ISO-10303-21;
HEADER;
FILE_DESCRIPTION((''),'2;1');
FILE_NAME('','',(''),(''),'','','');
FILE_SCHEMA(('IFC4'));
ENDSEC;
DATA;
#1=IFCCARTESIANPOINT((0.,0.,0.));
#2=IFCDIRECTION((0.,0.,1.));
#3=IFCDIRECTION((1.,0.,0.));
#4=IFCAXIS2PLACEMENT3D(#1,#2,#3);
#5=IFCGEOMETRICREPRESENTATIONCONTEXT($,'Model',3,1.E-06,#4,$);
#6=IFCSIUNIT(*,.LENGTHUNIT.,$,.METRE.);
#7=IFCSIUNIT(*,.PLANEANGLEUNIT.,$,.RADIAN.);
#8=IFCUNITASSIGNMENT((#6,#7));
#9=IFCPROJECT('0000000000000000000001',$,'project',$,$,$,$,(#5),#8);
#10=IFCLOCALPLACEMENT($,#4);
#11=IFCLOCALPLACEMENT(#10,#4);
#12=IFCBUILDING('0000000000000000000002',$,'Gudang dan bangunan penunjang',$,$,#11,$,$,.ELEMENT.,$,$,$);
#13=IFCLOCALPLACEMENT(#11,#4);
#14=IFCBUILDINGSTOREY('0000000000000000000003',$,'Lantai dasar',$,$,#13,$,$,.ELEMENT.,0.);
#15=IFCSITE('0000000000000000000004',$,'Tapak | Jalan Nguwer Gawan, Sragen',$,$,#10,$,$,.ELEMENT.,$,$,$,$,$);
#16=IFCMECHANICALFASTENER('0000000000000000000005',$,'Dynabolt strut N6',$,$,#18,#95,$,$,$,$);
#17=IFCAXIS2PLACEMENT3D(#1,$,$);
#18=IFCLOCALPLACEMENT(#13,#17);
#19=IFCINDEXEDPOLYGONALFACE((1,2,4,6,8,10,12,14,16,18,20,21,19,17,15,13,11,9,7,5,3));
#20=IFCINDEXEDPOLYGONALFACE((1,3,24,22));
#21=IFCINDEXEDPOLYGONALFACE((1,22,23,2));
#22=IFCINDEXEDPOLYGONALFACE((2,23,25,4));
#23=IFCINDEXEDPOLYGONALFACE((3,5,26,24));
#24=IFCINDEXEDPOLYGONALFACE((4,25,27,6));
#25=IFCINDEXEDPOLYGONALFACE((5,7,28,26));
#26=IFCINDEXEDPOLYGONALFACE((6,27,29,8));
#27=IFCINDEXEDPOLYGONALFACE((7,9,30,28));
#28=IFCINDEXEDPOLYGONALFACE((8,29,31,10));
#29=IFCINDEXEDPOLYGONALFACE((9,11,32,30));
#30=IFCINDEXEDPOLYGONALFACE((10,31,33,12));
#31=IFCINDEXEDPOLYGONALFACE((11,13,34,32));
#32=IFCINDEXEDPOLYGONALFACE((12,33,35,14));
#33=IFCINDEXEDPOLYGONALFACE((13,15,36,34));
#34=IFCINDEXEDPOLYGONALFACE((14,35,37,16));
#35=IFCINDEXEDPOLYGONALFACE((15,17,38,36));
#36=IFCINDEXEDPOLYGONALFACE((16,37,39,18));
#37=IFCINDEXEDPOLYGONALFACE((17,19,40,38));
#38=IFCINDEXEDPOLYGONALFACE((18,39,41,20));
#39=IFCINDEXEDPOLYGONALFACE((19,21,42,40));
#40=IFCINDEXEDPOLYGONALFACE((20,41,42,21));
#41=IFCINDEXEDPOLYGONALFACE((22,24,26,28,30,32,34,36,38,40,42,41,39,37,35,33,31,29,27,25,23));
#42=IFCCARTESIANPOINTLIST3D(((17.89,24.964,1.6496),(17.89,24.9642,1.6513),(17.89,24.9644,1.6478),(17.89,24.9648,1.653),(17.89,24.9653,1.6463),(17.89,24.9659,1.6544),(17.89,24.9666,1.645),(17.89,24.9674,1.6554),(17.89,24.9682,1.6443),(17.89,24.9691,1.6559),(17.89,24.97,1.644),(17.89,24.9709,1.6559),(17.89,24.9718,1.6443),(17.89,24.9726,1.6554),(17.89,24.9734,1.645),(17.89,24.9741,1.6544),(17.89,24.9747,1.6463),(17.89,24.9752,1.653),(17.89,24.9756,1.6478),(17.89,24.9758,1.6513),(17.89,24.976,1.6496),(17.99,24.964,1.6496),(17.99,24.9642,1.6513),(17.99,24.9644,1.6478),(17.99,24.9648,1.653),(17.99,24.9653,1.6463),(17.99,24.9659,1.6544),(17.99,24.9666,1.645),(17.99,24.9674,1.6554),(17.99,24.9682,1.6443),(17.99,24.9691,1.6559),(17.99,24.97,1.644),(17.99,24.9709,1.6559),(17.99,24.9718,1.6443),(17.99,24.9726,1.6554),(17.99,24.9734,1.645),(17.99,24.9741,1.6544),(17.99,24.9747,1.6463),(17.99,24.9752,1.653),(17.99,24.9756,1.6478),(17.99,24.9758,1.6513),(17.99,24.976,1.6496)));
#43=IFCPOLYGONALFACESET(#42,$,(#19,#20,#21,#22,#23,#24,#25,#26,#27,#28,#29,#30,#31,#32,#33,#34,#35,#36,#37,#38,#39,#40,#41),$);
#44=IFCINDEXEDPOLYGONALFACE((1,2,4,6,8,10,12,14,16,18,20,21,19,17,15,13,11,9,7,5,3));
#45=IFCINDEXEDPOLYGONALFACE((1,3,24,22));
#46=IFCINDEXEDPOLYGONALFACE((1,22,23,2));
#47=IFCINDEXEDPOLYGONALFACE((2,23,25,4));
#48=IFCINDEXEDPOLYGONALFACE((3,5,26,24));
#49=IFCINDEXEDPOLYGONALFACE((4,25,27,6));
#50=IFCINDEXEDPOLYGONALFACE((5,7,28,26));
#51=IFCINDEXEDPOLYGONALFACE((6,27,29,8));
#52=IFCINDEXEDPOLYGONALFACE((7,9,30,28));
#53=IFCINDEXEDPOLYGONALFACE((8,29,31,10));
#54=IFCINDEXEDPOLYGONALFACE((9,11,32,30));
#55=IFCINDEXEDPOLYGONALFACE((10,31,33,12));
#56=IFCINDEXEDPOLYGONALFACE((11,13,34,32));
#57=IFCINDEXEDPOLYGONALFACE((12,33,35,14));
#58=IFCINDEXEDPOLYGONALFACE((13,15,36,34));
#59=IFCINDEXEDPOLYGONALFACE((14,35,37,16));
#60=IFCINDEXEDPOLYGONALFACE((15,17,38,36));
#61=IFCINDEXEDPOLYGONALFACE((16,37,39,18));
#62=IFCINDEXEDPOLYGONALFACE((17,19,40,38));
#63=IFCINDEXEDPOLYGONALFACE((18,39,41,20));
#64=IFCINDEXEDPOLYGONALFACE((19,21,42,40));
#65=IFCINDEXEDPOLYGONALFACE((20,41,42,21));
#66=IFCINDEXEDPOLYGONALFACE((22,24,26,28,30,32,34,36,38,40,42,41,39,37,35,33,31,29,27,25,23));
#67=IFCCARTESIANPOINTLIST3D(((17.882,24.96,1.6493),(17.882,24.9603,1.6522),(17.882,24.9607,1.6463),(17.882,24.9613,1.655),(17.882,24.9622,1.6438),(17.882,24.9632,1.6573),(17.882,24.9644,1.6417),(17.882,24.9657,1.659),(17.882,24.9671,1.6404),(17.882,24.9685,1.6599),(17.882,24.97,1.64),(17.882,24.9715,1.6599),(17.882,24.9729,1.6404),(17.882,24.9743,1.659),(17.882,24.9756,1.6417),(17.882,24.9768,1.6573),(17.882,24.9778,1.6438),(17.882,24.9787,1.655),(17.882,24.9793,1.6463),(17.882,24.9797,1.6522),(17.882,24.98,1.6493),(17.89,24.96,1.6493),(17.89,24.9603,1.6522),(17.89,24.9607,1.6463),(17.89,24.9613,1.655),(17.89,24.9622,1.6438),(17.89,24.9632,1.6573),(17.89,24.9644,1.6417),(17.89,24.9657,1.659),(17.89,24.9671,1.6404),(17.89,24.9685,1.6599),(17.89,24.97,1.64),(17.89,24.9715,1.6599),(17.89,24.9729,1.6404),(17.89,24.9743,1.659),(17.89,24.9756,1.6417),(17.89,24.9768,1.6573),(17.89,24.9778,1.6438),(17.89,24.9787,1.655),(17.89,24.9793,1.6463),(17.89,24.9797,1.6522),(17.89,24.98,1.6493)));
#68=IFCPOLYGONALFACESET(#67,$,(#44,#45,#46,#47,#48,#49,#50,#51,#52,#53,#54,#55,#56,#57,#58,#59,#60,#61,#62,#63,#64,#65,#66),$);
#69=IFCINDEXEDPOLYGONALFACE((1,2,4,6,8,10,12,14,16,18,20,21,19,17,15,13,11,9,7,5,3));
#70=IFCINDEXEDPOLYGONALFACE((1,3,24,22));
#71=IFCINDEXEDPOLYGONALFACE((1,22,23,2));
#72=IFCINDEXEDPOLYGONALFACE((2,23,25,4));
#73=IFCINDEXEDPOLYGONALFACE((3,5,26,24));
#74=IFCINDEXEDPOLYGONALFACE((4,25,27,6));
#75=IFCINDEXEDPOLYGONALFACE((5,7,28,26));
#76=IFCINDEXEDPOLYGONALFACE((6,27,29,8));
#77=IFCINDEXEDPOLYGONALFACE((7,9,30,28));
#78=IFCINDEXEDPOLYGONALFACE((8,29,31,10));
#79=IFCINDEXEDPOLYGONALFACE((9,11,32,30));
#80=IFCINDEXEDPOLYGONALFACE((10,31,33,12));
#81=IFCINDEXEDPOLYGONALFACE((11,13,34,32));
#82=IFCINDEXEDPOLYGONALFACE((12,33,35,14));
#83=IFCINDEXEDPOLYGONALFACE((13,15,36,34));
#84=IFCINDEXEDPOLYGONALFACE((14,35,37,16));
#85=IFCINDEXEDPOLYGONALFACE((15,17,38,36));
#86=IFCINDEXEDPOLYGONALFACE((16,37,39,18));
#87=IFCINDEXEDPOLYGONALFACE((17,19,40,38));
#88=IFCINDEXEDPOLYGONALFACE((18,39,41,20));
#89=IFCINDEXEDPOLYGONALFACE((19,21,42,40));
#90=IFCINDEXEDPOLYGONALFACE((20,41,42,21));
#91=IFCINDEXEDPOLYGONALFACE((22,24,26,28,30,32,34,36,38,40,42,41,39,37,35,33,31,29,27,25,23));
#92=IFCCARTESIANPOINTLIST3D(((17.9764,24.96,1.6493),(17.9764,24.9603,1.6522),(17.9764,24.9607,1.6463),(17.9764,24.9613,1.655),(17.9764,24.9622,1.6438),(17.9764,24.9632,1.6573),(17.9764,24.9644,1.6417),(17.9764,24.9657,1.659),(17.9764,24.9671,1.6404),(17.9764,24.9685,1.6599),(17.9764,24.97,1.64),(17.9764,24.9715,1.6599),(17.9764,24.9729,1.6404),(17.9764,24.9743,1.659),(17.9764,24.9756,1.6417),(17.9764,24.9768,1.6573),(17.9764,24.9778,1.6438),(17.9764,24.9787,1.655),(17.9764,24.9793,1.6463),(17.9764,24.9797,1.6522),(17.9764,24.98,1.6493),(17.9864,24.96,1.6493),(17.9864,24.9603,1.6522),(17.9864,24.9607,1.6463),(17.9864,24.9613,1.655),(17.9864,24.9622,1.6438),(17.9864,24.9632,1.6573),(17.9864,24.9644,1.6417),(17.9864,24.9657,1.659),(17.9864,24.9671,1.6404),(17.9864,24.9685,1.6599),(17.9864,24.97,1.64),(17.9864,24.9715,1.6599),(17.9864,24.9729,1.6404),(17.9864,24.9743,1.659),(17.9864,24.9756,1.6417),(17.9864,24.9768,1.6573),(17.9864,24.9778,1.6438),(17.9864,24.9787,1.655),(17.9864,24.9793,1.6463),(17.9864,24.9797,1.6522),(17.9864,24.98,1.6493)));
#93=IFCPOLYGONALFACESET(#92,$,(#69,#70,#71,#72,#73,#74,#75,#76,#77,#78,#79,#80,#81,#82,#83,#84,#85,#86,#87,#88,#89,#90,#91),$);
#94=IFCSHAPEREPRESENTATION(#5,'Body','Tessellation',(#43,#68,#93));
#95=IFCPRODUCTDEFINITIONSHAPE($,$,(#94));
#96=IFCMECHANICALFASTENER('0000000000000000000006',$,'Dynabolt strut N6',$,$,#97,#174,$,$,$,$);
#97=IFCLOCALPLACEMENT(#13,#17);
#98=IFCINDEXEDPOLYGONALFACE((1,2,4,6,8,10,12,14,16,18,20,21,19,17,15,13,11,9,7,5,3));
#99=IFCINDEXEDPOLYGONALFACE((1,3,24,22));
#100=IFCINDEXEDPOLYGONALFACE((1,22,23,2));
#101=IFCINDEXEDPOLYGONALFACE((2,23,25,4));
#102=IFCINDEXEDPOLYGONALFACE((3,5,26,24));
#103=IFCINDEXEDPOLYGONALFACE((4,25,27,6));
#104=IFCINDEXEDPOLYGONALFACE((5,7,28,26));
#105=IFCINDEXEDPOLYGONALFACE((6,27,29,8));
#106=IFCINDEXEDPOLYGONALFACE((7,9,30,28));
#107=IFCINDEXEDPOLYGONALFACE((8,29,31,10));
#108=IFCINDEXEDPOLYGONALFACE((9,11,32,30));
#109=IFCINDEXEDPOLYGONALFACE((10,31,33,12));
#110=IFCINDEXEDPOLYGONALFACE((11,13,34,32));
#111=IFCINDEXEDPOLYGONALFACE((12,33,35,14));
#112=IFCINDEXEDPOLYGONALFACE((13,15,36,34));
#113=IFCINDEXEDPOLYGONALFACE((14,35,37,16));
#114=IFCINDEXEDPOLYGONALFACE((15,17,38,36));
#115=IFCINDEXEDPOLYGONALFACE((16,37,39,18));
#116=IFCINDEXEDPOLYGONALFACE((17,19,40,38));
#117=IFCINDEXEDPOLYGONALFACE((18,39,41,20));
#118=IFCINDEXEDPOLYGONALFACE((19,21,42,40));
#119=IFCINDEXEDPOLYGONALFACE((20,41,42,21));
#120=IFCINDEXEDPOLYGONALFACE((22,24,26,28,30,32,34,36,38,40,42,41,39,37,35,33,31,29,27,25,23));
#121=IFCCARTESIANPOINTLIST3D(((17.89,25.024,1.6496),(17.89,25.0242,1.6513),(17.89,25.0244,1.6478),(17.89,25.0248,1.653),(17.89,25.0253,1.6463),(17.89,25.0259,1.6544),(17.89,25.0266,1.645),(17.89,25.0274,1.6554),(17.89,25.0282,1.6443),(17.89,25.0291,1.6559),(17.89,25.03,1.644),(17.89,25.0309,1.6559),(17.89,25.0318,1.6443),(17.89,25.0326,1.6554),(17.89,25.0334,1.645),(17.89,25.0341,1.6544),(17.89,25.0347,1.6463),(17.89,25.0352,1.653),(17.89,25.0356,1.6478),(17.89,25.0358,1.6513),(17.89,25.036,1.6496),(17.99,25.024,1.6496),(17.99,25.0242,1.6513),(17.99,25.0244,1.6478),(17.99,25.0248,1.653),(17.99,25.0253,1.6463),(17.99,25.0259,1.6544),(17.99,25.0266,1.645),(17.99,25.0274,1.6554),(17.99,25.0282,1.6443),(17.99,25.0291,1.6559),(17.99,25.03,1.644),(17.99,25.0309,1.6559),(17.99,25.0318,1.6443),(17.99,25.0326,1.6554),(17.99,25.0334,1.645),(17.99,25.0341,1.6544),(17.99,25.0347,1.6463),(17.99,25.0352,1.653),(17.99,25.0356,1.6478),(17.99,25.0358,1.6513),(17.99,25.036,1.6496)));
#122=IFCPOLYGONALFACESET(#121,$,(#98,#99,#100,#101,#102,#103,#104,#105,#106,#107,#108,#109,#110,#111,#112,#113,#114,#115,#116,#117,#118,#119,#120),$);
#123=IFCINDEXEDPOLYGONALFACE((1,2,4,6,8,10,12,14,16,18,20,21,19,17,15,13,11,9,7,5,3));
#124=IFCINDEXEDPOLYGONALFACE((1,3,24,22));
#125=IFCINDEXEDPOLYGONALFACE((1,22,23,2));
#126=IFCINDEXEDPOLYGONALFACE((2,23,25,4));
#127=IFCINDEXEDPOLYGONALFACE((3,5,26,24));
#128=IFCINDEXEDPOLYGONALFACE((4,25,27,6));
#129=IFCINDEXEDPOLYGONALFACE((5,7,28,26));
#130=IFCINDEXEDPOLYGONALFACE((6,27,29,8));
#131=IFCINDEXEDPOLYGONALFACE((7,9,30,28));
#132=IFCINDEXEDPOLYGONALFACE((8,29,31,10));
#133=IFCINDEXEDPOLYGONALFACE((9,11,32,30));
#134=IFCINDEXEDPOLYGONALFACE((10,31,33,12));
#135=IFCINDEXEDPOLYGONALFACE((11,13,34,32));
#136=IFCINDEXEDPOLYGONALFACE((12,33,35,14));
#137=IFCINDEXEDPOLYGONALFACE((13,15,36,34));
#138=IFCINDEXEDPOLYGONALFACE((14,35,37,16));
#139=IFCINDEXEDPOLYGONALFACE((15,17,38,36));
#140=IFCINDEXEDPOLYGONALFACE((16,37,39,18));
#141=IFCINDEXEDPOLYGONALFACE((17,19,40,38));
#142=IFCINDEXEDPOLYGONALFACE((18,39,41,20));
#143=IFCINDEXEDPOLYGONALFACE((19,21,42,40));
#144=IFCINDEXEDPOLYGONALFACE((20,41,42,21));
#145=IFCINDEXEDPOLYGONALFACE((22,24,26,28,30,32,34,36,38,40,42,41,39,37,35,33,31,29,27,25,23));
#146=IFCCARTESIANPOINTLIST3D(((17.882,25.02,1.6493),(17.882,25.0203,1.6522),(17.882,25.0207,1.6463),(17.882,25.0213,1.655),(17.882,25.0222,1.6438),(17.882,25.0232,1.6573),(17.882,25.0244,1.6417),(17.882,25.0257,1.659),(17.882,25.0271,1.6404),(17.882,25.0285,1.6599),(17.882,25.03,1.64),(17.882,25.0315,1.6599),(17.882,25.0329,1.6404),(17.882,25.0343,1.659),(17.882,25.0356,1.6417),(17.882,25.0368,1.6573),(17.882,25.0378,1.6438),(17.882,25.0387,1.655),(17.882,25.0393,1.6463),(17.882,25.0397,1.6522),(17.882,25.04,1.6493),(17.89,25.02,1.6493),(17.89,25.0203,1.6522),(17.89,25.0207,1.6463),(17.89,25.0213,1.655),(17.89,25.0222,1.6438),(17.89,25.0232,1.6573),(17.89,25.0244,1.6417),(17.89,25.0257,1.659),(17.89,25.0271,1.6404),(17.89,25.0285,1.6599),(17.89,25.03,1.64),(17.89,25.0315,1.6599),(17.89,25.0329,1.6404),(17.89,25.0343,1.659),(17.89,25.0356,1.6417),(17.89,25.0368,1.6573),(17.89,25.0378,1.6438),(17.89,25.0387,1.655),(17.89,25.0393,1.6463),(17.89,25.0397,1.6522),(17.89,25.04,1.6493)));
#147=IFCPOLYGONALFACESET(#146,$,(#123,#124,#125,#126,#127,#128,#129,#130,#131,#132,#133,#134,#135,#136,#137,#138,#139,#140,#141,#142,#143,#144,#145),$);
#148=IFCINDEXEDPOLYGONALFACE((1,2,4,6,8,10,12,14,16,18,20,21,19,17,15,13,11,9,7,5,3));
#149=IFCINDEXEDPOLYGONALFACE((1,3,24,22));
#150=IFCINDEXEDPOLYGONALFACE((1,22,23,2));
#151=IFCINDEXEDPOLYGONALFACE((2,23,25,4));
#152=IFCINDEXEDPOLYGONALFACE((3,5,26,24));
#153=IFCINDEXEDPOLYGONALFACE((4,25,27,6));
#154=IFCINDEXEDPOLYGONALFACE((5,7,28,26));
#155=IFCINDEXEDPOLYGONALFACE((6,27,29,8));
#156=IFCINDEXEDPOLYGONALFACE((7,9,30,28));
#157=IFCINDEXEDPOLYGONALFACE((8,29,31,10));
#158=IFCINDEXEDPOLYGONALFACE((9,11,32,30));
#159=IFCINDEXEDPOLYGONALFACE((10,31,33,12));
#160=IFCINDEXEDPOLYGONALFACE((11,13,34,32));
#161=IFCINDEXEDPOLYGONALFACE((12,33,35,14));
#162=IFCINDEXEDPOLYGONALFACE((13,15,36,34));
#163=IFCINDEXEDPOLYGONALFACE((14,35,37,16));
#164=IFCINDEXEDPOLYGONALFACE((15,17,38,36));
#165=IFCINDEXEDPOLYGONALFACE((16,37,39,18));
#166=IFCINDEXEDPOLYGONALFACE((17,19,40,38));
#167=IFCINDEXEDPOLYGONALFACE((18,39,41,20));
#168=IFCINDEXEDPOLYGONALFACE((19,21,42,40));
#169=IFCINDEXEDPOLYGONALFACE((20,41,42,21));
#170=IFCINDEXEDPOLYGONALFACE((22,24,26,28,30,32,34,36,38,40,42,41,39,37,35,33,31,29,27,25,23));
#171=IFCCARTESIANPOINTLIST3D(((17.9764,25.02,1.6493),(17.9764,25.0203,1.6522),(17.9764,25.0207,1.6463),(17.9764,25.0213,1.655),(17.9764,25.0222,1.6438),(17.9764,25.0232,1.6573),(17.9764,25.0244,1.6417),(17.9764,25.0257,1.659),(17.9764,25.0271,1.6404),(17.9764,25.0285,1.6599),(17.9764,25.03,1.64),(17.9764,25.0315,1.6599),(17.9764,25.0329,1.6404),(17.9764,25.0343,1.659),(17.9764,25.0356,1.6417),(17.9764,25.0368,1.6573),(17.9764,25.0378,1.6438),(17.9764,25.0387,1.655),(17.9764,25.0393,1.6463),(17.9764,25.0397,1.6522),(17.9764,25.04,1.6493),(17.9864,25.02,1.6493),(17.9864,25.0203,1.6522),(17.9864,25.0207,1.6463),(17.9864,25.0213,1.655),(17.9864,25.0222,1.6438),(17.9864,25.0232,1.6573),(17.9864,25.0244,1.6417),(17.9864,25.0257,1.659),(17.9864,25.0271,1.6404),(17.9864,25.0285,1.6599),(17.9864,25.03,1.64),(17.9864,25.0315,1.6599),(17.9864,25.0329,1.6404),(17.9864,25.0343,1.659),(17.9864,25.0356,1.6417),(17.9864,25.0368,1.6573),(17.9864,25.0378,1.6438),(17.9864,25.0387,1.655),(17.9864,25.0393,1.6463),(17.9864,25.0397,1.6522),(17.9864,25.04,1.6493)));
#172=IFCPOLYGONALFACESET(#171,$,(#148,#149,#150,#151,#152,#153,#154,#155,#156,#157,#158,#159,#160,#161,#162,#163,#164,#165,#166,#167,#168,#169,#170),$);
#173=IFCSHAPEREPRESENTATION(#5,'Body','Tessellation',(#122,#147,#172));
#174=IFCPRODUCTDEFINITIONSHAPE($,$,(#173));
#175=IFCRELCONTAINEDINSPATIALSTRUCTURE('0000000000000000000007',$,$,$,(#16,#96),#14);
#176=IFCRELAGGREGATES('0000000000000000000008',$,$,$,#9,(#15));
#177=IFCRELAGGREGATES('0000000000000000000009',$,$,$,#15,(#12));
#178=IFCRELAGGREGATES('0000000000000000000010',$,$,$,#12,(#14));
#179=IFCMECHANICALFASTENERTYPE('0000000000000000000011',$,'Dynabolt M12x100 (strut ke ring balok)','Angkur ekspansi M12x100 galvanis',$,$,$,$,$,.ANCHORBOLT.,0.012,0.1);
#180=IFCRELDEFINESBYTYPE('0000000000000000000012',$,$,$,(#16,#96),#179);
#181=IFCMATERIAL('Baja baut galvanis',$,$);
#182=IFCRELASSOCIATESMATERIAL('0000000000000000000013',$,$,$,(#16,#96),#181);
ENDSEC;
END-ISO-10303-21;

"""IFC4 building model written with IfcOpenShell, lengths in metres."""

from ifc_helpers import new_model, si_unit, frame, origin_with_axes, place, context, project, spatial, circle, extrude, source, transform, mapped, material, type_object, type_shapes, element, save


model = new_model("IFC4")

# Units and contexts
model_context = context("Model", 3, precision=1e-06, world=origin_with_axes())
ifc_project = project(units=[si_unit("LENGTHUNIT", "METRE"), si_unit("PLANEANGLEUNIT", "RADIAN")], contexts=[model_context])

# Site, building, storey
site_placement = place(None, origin_with_axes())
site = spatial("IfcSite", under=ifc_project, at=site_placement, Name="Tapak | Jalan Nguwer Gawan, Sragen", CompositionType="ELEMENT")
building_placement = place(site_placement, origin_with_axes())
building = spatial("IfcBuilding", under=site, at=building_placement, Name="Gudang dan bangunan penunjang", CompositionType="ELEMENT")
storey_placement = place(building_placement, origin_with_axes())
storey = spatial("IfcBuildingStorey", under=building, at=storey_placement, Name="Lantai dasar", CompositionType="ELEMENT", Elevation=0.0)

# Mechanical fasteners
ifc_material = material(Name="Baja baut galvanis")
mechanical_fastener_type = type_object("IfcMechanicalFastenerType", Name="Dynabolt M12x100 (strut ke ring balok)", Description="Angkur ekspansi M12x100 galvanis", NominalDiameter=0.012, NominalLength=0.1, PredefinedType="ANCHORBOLT")
shared_shape = source(origin_with_axes(), model_context, "Body", "SweptSolid", [
    extrude(circle(Radius=0.006), origin_with_axes(), (0.0, 0.0, 1.0), 0.1),
    extrude(circle(Radius=0.01), frame((0.0, 0.0, -0.008), z_axis=(0.0, 0.0, 1.0), x_axis=(1.0, 0.0, 0.0)), (0.0, 0.0, 1.0), 0.008),
    extrude(circle(Radius=0.01), frame((0.0, 0.0, 0.0864), z_axis=(0.0, 0.0, 1.0), x_axis=(1.0, 0.0, 0.0)), (0.0, 0.0, 1.0), 0.01),
])
type_shapes(mechanical_fastener_type, [shared_shape])
placement = place(None, origin_with_axes())
element("IfcMechanicalFastener", 1, at=placement, inside=storey, type_object=mechanical_fastener_type, material=ifc_material, Name="Dynabolt strut N6", context=model_context, shape_type="MappedRepresentation", body=[
    mapped(shared_shape, transform((17.89, 24.97, 1.65), x_axis=(0.0, 0.0, -1.0), y_axis=(0.0, 1.0, 0.0), z_axis=(1.0, 0.0, 0.0), scale=1.0)),
])
element("IfcMechanicalFastener", 2, at=placement, inside=storey, type_object=mechanical_fastener_type, material=ifc_material, Name="Dynabolt strut N6", context=model_context, shape_type="MappedRepresentation", body=[
    mapped(shared_shape, transform((17.89, 25.03, 1.65), x_axis=(0.0, 0.0, -1.0), y_axis=(0.0, 1.0, 0.0), z_axis=(1.0, 0.0, 0.0), scale=1.0)),
])

save(model, "model.ifc")
